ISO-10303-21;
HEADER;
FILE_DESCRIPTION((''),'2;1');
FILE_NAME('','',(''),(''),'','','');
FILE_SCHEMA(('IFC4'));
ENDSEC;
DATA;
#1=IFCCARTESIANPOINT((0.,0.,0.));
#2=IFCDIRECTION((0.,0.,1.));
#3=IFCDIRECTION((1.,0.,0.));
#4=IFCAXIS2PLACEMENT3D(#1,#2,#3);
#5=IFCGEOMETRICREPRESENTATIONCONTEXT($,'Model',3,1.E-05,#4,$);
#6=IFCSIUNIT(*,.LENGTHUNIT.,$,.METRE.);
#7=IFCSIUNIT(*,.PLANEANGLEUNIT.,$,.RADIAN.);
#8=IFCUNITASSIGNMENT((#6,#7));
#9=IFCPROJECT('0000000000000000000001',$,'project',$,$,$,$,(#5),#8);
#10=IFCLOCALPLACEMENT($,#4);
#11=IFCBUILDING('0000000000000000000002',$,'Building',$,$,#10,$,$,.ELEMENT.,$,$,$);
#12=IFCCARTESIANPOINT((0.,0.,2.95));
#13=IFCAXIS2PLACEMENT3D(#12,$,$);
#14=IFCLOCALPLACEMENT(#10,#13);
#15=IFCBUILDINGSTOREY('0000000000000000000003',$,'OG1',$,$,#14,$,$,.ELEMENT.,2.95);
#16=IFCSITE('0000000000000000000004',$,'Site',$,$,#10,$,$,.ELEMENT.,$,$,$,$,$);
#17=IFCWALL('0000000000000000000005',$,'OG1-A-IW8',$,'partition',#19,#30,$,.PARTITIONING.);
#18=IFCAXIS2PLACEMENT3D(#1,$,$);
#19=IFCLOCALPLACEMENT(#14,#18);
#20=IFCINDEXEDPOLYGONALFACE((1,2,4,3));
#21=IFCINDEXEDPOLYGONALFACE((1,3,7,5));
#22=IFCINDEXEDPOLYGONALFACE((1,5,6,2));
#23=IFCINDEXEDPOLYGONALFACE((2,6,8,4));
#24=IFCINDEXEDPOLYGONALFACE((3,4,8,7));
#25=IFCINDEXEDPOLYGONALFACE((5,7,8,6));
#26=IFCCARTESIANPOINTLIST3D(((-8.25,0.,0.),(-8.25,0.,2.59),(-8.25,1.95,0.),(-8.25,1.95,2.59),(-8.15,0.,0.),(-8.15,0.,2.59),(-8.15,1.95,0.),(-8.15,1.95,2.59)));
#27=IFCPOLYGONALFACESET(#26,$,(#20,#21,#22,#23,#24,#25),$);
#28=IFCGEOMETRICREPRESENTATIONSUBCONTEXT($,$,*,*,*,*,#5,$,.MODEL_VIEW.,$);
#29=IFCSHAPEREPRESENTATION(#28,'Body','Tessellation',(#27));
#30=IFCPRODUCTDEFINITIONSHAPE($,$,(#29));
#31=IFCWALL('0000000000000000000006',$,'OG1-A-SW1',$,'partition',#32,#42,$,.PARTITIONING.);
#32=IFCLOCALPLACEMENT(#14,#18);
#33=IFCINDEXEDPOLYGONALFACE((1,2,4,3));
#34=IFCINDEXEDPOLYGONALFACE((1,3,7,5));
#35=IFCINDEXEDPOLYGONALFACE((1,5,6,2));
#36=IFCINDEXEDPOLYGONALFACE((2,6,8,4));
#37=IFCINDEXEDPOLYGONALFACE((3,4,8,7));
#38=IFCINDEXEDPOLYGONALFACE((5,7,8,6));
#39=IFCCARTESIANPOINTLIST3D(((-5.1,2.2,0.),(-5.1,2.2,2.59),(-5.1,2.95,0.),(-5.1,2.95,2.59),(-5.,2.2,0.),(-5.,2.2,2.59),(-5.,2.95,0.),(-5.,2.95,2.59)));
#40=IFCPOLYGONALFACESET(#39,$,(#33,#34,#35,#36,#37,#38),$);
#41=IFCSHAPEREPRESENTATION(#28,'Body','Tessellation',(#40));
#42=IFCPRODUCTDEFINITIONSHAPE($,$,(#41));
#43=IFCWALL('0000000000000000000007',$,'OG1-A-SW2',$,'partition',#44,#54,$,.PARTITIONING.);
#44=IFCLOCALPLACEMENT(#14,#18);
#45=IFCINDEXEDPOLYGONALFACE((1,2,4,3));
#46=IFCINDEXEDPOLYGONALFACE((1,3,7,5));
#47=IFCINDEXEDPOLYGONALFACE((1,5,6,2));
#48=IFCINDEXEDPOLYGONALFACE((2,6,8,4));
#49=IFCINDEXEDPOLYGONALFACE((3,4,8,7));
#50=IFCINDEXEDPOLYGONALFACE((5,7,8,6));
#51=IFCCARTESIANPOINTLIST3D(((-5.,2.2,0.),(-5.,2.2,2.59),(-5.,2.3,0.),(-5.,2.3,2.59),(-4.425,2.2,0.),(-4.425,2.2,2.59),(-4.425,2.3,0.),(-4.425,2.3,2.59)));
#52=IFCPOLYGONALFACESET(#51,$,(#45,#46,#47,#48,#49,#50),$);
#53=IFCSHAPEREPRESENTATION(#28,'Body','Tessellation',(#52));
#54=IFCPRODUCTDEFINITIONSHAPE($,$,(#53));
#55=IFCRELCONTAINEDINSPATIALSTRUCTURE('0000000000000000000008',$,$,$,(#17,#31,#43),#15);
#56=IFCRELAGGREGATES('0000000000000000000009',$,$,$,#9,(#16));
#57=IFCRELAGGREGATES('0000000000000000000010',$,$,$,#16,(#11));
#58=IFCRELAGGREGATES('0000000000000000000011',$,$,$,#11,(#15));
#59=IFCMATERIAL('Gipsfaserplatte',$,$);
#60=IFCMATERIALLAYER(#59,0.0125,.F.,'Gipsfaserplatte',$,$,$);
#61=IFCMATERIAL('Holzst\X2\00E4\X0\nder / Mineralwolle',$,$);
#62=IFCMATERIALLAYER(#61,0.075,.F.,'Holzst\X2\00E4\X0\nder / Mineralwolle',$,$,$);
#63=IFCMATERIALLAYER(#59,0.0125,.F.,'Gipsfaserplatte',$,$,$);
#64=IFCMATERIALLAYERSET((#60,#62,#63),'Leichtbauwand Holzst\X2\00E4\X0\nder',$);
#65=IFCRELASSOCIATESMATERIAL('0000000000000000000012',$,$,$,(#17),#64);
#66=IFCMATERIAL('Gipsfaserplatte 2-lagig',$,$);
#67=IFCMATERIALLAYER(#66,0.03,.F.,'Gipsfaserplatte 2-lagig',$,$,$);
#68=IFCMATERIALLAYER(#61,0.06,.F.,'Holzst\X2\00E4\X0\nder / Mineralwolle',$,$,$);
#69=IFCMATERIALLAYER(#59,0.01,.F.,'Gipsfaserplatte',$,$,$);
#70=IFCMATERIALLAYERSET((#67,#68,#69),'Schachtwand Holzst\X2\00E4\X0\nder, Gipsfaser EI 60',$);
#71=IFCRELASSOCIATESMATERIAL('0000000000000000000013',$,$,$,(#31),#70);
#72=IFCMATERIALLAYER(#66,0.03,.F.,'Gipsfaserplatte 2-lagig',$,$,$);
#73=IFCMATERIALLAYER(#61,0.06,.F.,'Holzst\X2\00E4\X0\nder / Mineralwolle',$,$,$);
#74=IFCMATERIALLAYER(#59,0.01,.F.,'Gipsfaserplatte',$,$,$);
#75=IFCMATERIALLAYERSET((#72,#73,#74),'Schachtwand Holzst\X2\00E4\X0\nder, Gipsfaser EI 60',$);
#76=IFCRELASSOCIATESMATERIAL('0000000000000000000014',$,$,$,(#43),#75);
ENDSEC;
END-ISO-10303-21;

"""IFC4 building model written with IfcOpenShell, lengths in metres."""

from ifc_helpers import new_model, si_unit, frame, frame_2d, origin, origin_with_axes, place, context, subcontext, project, spatial, rectangle, extrude, material, layer, layer_set, element, save


model = new_model("IFC4")

# Units and contexts
model_context = context("Model", 3, precision=1e-05, world=origin_with_axes())
sub_context = subcontext(model_context, None, None, "MODEL_VIEW")
ifc_project = project(units=[si_unit("LENGTHUNIT", "METRE"), si_unit("PLANEANGLEUNIT", "RADIAN")], contexts=[model_context])

# Site, building, storey
placement = place(None, origin_with_axes())
site = spatial("IfcSite", under=ifc_project, at=placement, Name="Site", CompositionType="ELEMENT")
building = spatial("IfcBuilding", under=site, at=placement, Name="Building", CompositionType="ELEMENT")
storey_placement = place(placement, frame((0.0, 0.0, 2.95)))
storey = spatial("IfcBuildingStorey", under=building, at=storey_placement, Name="OG1", CompositionType="ELEMENT", Elevation=2.95)

# Shared definitions
ifc_material_1 = material(Name="Gipsfaserplatte")

# Shared definitions
ifc_material_2 = material(Name="Gipsfaserplatte 2-lagig")

# Shared definitions
ifc_material_3 = material(Name="Holzständer / Mineralwolle")

# Walls
ifc_layer_1 = layer(ifc_material_1, 0.0125, ventilated=False, Name="Gipsfaserplatte")
ifc_layer_2 = layer(ifc_material_3, 0.075, ventilated=False, Name="Holzständer / Mineralwolle")
ifc_layer_3 = layer(ifc_material_1, 0.0125, ventilated=False, Name="Gipsfaserplatte")
ifc_layer_set_1 = layer_set([ifc_layer_1, ifc_layer_2, ifc_layer_3], Name="Leichtbauwand Holzständer")
wall_1_placement = place(storey_placement, frame((-8.2, 0.0, 0.0), z_axis=(0.0, 0.0, 1.0), x_axis=(0.0, 1.0, 0.0)))
element("IfcWall", 1, at=wall_1_placement, inside=storey, material=ifc_layer_set_1, Name="OG1-A-IW8", ObjectType="partition", PredefinedType="PARTITIONING", context=sub_context, shape_type="SweptSolid", body=[
    extrude(rectangle(XDim=1.95, YDim=0.1, at=frame_2d((0.975, 0.0))), origin(), (0.0, 0.0, 1.0), 2.59),
])
ifc_layer_4 = layer(ifc_material_2, 0.03, ventilated=False, Name="Gipsfaserplatte 2-lagig")
ifc_layer_5 = layer(ifc_material_3, 0.06, ventilated=False, Name="Holzständer / Mineralwolle")
ifc_layer_6 = layer(ifc_material_1, 0.01, ventilated=False, Name="Gipsfaserplatte")
ifc_layer_set_2 = layer_set([ifc_layer_4, ifc_layer_5, ifc_layer_6], Name="Schachtwand Holzständer, Gipsfaser EI 60")
wall_2_placement = place(storey_placement, frame((-5.05, 2.2, 0.0), z_axis=(0.0, 0.0, 1.0), x_axis=(0.0, 1.0, 0.0)))
element("IfcWall", 2, at=wall_2_placement, inside=storey, material=ifc_layer_set_2, Name="OG1-A-SW1", ObjectType="partition", PredefinedType="PARTITIONING", context=sub_context, shape_type="SweptSolid", body=[
    extrude(rectangle(XDim=0.75, YDim=0.1, at=frame_2d((0.375, 0.0))), origin(), (0.0, 0.0, 1.0), 2.59),
])
ifc_layer_7 = layer(ifc_material_2, 0.03, ventilated=False, Name="Gipsfaserplatte 2-lagig")
ifc_layer_8 = layer(ifc_material_3, 0.06, ventilated=False, Name="Holzständer / Mineralwolle")
ifc_layer_9 = layer(ifc_material_1, 0.01, ventilated=False, Name="Gipsfaserplatte")
ifc_layer_set_3 = layer_set([ifc_layer_7, ifc_layer_8, ifc_layer_9], Name="Schachtwand Holzständer, Gipsfaser EI 60")
wall_3_placement = place(storey_placement, frame((-5.0, 2.25, 0.0), z_axis=(0.0, 0.0, 1.0), x_axis=(1.0, 0.0, 0.0)))
element("IfcWall", 3, at=wall_3_placement, inside=storey, material=ifc_layer_set_3, Name="OG1-A-SW2", ObjectType="partition", PredefinedType="PARTITIONING", context=sub_context, shape_type="SweptSolid", body=[
    extrude(rectangle(XDim=0.575, YDim=0.1, at=frame_2d((0.2875, 0.0))), origin(), (0.0, 0.0, 1.0), 2.59),
])

save(model, "model.ifc")
